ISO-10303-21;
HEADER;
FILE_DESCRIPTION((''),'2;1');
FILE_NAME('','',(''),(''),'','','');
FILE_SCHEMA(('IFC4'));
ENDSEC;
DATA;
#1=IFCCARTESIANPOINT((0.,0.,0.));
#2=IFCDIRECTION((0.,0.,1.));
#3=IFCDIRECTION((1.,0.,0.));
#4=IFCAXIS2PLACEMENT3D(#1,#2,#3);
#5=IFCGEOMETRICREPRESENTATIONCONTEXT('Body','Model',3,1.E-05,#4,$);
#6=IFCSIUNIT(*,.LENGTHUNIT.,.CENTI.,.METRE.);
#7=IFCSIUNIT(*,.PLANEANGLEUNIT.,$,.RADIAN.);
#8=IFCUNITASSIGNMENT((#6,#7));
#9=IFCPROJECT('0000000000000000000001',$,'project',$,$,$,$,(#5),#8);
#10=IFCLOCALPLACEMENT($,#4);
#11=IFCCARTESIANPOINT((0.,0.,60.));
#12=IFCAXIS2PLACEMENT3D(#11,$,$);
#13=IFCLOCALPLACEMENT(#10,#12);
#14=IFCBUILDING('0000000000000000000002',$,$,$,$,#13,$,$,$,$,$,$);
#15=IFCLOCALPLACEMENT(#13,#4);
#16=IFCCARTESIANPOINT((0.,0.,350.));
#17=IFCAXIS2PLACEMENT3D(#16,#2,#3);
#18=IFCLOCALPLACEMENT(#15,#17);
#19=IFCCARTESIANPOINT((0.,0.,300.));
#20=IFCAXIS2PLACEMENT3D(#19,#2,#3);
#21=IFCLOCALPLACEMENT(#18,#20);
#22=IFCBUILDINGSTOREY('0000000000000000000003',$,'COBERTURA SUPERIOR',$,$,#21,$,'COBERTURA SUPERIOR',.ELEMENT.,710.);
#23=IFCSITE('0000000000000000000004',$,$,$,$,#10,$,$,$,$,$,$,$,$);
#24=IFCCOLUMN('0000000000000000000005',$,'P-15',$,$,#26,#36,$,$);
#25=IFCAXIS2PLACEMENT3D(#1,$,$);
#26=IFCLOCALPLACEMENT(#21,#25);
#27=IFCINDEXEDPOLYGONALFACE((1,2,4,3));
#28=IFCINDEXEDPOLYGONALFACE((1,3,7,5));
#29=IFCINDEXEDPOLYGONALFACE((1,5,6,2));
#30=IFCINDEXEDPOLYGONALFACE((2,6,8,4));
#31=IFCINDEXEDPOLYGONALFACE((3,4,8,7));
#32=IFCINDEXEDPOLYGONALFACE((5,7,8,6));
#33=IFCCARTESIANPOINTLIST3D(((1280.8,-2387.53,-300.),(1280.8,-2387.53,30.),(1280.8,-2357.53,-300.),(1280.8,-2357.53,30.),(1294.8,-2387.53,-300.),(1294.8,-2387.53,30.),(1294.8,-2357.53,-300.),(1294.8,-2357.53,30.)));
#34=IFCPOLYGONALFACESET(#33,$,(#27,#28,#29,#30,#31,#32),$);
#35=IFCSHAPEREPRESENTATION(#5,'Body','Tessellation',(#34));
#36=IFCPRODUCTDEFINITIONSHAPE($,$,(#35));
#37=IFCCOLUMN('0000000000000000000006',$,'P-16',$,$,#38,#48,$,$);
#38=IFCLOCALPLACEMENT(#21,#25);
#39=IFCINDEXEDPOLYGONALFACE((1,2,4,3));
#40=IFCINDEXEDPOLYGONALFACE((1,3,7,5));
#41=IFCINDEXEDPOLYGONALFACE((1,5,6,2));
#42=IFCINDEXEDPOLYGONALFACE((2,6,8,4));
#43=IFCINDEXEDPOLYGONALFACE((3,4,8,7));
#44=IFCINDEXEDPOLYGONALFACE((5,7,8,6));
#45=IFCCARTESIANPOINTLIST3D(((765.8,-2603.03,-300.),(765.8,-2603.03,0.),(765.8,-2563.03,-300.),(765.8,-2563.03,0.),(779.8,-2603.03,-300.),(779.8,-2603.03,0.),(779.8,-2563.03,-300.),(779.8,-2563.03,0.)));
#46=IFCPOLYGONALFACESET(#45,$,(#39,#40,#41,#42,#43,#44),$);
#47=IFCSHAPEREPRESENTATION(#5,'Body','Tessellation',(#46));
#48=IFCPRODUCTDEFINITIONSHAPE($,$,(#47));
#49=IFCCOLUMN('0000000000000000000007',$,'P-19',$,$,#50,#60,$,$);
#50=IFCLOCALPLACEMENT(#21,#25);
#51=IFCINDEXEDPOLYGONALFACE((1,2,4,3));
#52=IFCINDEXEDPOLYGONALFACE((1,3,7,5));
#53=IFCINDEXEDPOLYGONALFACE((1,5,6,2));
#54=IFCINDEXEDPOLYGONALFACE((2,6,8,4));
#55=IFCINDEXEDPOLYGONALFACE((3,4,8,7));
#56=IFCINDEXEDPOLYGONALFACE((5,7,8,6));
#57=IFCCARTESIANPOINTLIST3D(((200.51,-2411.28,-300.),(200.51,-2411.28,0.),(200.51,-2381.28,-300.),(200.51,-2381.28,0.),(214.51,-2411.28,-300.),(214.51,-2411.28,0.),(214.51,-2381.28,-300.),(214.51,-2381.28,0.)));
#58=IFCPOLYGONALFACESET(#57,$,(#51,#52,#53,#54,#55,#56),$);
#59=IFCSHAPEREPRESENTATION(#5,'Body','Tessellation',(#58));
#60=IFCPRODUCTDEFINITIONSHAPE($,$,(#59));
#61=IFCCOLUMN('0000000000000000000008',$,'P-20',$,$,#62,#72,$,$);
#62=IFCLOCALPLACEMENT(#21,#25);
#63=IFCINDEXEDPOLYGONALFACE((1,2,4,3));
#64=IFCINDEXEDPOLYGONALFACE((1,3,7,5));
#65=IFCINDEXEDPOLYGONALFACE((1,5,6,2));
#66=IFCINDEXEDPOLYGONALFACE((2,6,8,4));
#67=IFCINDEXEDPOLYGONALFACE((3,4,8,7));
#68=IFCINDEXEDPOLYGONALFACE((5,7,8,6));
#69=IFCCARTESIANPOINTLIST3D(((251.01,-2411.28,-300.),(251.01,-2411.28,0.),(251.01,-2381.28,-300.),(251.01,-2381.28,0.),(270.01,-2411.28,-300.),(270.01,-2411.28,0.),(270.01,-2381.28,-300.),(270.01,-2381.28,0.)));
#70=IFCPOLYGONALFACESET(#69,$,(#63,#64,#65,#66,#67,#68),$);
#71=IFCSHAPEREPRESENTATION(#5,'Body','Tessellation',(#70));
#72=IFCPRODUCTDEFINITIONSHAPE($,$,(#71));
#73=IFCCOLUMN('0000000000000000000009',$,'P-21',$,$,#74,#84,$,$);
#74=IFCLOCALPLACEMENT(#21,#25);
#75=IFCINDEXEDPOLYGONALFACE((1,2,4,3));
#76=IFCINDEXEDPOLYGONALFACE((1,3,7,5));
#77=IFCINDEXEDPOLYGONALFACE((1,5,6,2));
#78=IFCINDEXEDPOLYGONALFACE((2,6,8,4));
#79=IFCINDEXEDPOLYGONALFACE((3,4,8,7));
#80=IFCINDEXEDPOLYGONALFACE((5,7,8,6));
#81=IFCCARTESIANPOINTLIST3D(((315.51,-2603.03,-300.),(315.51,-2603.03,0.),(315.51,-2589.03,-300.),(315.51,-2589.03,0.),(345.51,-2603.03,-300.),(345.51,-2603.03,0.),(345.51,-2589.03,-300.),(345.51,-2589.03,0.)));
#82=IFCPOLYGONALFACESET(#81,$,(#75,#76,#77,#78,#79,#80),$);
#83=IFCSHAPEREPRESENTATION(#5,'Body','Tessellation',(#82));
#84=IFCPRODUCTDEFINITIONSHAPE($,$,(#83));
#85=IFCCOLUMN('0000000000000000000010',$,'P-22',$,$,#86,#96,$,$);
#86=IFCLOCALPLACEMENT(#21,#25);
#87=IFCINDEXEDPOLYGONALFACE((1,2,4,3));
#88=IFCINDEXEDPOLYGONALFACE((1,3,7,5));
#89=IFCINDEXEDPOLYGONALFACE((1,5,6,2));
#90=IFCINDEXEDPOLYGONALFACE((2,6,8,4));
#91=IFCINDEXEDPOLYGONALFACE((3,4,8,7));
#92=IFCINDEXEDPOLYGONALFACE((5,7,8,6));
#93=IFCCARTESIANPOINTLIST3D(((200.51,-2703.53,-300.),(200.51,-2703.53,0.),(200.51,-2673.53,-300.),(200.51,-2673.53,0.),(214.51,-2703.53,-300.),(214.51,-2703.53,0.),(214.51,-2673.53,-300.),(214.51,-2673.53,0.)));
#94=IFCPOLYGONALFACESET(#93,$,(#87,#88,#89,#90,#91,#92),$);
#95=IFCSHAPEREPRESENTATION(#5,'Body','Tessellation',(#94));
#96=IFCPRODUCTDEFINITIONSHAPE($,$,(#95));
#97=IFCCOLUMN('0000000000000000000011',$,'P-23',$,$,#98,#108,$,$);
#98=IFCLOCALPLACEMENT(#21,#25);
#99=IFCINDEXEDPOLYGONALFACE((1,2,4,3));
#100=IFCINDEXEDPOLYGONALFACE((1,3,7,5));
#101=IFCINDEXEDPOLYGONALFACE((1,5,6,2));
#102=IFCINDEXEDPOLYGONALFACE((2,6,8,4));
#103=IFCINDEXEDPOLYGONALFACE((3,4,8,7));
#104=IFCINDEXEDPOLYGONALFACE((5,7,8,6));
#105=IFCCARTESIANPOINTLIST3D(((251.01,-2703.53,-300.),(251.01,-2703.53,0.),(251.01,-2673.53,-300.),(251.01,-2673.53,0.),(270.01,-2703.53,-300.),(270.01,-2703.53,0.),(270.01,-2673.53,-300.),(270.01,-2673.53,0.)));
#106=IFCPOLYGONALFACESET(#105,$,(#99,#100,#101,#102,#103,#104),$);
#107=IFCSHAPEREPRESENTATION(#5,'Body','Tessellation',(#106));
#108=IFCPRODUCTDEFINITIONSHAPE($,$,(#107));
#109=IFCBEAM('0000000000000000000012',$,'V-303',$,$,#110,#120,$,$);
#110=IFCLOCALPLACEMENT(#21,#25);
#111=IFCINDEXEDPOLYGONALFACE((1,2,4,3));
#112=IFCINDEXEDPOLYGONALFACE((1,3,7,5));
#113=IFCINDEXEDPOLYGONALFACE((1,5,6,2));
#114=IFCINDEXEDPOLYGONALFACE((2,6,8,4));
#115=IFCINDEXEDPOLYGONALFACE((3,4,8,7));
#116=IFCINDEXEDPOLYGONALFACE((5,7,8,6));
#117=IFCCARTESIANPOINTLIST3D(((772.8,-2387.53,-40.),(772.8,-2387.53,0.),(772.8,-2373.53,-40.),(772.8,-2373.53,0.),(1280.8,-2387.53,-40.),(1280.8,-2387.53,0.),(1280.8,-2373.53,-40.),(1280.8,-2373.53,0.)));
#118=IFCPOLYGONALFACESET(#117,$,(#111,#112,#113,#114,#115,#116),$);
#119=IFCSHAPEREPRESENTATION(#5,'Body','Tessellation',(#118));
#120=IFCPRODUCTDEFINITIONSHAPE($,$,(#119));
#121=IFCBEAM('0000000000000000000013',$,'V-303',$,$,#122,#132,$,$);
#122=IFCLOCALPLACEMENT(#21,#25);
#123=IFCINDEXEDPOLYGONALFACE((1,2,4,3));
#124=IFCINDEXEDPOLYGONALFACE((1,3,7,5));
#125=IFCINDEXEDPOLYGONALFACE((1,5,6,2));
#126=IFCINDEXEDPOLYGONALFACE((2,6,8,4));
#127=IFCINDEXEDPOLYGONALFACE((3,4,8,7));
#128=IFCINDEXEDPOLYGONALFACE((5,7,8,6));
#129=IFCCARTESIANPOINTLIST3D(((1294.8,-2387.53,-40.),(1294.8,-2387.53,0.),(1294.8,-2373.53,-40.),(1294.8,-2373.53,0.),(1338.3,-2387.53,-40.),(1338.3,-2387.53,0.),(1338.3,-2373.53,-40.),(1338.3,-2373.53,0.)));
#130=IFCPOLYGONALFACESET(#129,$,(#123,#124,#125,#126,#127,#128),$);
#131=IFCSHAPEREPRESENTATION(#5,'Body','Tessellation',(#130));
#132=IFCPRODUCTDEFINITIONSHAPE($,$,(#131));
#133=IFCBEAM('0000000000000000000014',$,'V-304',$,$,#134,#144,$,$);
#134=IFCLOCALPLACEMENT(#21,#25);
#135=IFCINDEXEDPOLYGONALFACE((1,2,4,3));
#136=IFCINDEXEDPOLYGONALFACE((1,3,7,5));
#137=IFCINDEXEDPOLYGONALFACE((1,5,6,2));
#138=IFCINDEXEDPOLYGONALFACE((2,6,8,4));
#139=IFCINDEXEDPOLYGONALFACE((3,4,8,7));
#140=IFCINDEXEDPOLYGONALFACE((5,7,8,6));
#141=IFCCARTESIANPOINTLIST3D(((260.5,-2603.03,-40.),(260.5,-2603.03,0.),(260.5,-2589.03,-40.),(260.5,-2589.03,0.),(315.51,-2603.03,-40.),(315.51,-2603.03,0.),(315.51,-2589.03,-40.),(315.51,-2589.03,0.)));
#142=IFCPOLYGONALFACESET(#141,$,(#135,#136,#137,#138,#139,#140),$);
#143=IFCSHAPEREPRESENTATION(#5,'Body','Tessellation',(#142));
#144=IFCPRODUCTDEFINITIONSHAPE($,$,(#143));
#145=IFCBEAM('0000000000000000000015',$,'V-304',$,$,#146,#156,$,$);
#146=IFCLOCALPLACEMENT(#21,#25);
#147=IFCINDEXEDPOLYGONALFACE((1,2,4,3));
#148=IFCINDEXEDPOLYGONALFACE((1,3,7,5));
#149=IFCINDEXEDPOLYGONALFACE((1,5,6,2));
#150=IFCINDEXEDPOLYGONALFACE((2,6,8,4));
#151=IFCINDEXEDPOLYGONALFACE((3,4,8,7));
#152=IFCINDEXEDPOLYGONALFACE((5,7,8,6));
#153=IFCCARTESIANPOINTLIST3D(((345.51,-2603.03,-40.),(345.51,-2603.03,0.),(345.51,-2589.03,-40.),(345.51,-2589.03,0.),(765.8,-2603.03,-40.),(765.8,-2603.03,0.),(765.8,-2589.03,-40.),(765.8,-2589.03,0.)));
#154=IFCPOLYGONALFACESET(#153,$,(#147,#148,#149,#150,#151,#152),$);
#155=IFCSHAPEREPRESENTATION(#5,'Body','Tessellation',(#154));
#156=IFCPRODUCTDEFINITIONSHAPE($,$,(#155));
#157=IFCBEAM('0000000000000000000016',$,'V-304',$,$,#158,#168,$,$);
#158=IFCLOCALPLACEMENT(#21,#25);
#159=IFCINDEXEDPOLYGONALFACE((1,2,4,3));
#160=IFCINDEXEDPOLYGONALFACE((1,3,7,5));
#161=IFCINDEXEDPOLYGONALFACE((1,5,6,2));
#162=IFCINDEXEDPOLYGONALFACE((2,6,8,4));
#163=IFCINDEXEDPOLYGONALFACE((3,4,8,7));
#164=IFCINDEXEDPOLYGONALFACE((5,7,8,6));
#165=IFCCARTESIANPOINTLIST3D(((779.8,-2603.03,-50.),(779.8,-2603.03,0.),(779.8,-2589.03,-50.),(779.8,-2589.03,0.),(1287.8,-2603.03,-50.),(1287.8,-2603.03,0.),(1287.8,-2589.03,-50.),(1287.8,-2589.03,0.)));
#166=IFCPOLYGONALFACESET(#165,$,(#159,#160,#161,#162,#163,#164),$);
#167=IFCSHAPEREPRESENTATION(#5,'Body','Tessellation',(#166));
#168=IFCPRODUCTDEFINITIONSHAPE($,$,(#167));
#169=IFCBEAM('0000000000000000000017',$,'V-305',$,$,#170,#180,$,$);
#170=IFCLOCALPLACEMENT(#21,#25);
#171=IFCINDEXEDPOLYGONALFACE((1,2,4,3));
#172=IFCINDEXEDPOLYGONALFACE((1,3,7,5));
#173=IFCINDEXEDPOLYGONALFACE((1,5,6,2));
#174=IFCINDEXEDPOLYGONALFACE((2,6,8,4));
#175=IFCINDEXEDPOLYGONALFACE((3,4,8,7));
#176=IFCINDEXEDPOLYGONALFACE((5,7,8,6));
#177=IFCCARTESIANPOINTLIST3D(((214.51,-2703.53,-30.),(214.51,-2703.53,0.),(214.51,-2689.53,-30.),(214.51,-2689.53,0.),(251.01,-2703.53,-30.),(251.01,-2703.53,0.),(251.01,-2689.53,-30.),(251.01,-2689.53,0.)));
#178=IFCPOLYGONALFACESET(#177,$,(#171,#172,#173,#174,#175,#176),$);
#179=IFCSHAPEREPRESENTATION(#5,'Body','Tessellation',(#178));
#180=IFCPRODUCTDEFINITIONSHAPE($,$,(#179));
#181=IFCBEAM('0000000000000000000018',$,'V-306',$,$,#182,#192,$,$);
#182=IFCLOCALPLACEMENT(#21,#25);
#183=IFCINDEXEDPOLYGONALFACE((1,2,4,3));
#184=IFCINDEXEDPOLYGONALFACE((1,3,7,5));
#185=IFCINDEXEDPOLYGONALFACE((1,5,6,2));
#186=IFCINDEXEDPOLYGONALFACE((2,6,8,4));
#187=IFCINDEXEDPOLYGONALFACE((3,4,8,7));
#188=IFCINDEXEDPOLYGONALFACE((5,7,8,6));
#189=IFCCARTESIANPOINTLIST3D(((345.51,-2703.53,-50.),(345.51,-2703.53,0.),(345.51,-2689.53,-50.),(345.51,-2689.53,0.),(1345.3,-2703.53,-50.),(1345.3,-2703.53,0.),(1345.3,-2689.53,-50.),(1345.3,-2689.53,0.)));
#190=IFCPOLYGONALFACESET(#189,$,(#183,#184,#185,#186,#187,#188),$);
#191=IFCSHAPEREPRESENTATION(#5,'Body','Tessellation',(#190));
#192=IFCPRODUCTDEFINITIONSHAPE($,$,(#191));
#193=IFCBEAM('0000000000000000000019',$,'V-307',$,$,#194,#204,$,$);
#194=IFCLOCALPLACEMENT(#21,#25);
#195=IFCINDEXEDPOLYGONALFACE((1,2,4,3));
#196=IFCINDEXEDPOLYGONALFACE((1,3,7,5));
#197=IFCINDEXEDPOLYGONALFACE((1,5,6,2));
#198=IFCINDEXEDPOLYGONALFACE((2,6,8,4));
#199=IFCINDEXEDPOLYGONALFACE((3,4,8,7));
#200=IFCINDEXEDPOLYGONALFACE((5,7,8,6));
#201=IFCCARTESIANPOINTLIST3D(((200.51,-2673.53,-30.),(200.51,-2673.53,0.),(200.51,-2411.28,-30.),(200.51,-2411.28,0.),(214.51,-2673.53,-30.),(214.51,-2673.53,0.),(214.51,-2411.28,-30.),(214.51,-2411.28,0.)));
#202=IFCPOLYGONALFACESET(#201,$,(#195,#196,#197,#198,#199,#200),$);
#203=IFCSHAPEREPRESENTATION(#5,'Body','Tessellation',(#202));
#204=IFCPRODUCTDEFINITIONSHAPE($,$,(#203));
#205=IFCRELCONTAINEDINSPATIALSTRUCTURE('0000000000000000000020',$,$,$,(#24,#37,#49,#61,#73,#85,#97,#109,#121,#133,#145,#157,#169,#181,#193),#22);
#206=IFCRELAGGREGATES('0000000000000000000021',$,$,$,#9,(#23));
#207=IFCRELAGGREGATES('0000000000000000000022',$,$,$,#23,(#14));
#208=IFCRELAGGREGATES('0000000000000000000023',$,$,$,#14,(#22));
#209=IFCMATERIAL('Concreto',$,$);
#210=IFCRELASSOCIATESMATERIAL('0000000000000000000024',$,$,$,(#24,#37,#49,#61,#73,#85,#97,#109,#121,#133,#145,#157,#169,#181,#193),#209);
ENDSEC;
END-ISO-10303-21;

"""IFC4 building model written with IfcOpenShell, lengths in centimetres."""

from ifc_helpers import new_model, si_unit, frame, origin_with_axes, origin_2d_with_axis, place, context, project, spatial, rectangle, extrude, material, element, save


model = new_model("IFC4")

# Units and contexts
model_context = context("Model", 3, precision=1e-05, world=origin_with_axes(), identifier="Body")
ifc_project = project(units=[si_unit("LENGTHUNIT", "METRE", prefix="CENTI"), si_unit("PLANEANGLEUNIT", "RADIAN")], contexts=[model_context])

# Site, building, storey
site_placement = place(None, origin_with_axes())
site = spatial("IfcSite", under=ifc_project, at=site_placement)
building_placement = place(site_placement, frame((0.0, 0.0, 60.0)))
building = spatial("IfcBuilding", under=site, at=building_placement)
placement_1 = place(building_placement, origin_with_axes())
placement_2 = place(placement_1, frame((0.0, 0.0, 350.0), z_axis=(0.0, 0.0, 1.0), x_axis=(1.0, 0.0, 0.0)))
storey_placement = place(placement_2, frame((0.0, 0.0, 300.0), z_axis=(0.0, 0.0, 1.0), x_axis=(1.0, 0.0, 0.0)))
storey = spatial("IfcBuildingStorey", under=building, at=storey_placement, Name="COBERTURA SUPERIOR", LongName="COBERTURA SUPERIOR", CompositionType="ELEMENT", Elevation=710.0)

# Columns
ifc_material = material(Name="Concreto")
column_1_placement = place(storey_placement, frame((1287.8, -2372.53, 30.0), z_axis=(0.0, 0.0, 1.0), x_axis=(1.0, 0.0, 0.0)))
element("IfcColumn", 1, at=column_1_placement, inside=storey, material=ifc_material, Name="P-15", context=model_context, shape_type="SolidModel", body=[
    extrude(rectangle(XDim=14.0, YDim=30.0, at=origin_2d_with_axis()), origin_with_axes(), (0.0, 0.0, -1.0), 330.0),
])
column_2_placement = place(storey_placement, frame((772.8, -2583.03, 0.0), z_axis=(0.0, 0.0, 1.0), x_axis=(1.0, 0.0, 0.0)))
element("IfcColumn", 2, at=column_2_placement, inside=storey, material=ifc_material, Name="P-16", context=model_context, shape_type="SolidModel", body=[
    extrude(rectangle(XDim=14.0, YDim=40.0, at=origin_2d_with_axis()), origin_with_axes(), (0.0, 0.0, -1.0), 300.0),
])
column_3_placement = place(storey_placement, frame((207.51, -2396.28, 0.0), z_axis=(0.0, 0.0, 1.0), x_axis=(1.0, 0.0, 0.0)))
element("IfcColumn", 3, at=column_3_placement, inside=storey, material=ifc_material, Name="P-19", context=model_context, shape_type="SolidModel", body=[
    extrude(rectangle(XDim=14.0, YDim=30.0, at=origin_2d_with_axis()), origin_with_axes(), (0.0, 0.0, -1.0), 300.0),
])
column_4_placement = place(storey_placement, frame((260.51, -2396.28, 0.0), z_axis=(0.0, 0.0, 1.0), x_axis=(1.0, 0.0, 0.0)))
element("IfcColumn", 4, at=column_4_placement, inside=storey, material=ifc_material, Name="P-20", context=model_context, shape_type="SolidModel", body=[
    extrude(rectangle(XDim=19.0, YDim=30.0, at=origin_2d_with_axis()), origin_with_axes(), (0.0, 0.0, -1.0), 300.0),
])
column_5_placement = place(storey_placement, frame((330.51, -2596.03, 0.0), z_axis=(0.0, 0.0, 1.0), x_axis=(1.0, 0.0, 0.0)))
element("IfcColumn", 5, at=column_5_placement, inside=storey, material=ifc_material, Name="P-21", context=model_context, shape_type="SolidModel", body=[
    extrude(rectangle(XDim=14.0, YDim=30.0, at=origin_2d_with_axis()), frame((0.0, 0.0, 0.0), z_axis=(0.0, 0.0, 1.0), x_axis=(0.0, -1.0, 0.0)), (0.0, 0.0, -1.0), 300.0),
])
column_6_placement = place(storey_placement, frame((207.51, -2688.53, 0.0), z_axis=(0.0, 0.0, 1.0), x_axis=(1.0, 0.0, 0.0)))
element("IfcColumn", 6, at=column_6_placement, inside=storey, material=ifc_material, Name="P-22", context=model_context, shape_type="SolidModel", body=[
    extrude(rectangle(XDim=14.0, YDim=30.0, at=origin_2d_with_axis()), origin_with_axes(), (0.0, 0.0, -1.0), 300.0),
])
column_7_placement = place(storey_placement, frame((260.51, -2688.53, 0.0), z_axis=(0.0, 0.0, 1.0), x_axis=(1.0, 0.0, 0.0)))
element("IfcColumn", 7, at=column_7_placement, inside=storey, material=ifc_material, Name="P-23", context=model_context, shape_type="SolidModel", body=[
    extrude(rectangle(XDim=19.0, YDim=30.0, at=origin_2d_with_axis()), origin_with_axes(), (0.0, 0.0, -1.0), 300.0),
])

# Beams
beam_1_placement = place(storey_placement, frame((1026.8, -2380.53, 0.0), z_axis=(0.0, 0.0, 1.0), x_axis=(1.0, 0.0, 0.0)))
element("IfcBeam", 8, at=beam_1_placement, inside=storey, material=ifc_material, Name="V-303", context=model_context, shape_type="SolidModel", body=[
    extrude(rectangle(XDim=14.0, YDim=40.0, at=origin_2d_with_axis()), frame((-254.0, 0.0, -20.0), z_axis=(1.0, 0.0, 0.0), x_axis=(0.0, -1.0, 0.0)), (0.0, 0.0, 1.0), 508.0),
])
beam_2_placement = place(storey_placement, frame((1316.55, -2380.53, 0.0), z_axis=(0.0, 0.0, 1.0), x_axis=(1.0, 0.0, 0.0)))
element("IfcBeam", 9, at=beam_2_placement, inside=storey, material=ifc_material, Name="V-303", context=model_context, shape_type="SolidModel", body=[
    extrude(rectangle(XDim=14.0, YDim=40.0, at=origin_2d_with_axis()), frame((-21.75, 0.0, -20.0), z_axis=(1.0, 0.0, 0.0), x_axis=(0.0, -1.0, 0.0)), (0.0, 0.0, 1.0), 43.5),
])
beam_3_placement = place(storey_placement, frame((288.0, -2596.03, 0.0), z_axis=(0.0, 0.0, 1.0), x_axis=(1.0, 0.0, 0.0)))
element("IfcBeam", 10, at=beam_3_placement, inside=storey, material=ifc_material, Name="V-304", context=model_context, shape_type="SolidModel", body=[
    extrude(rectangle(XDim=14.0, YDim=40.0, at=origin_2d_with_axis()), frame((-27.5, 0.0, -20.0), z_axis=(1.0, 0.0, 0.0), x_axis=(0.0, -1.0, 0.0)), (0.0, 0.0, 1.0), 55.01),
])
beam_4_placement = place(storey_placement, frame((555.65, -2596.03, 0.0), z_axis=(0.0, 0.0, 1.0), x_axis=(1.0, 0.0, 0.0)))
element("IfcBeam", 11, at=beam_4_placement, inside=storey, material=ifc_material, Name="V-304", context=model_context, shape_type="SolidModel", body=[
    extrude(rectangle(XDim=14.0, YDim=40.0, at=origin_2d_with_axis()), frame((-210.15, 0.0, -20.0), z_axis=(1.0, 0.0, 0.0), x_axis=(0.0, -1.0, 0.0)), (0.0, 0.0, 1.0), 420.29),
])
beam_5_placement = place(storey_placement, frame((1033.8, -2596.03, 0.0), z_axis=(0.0, 0.0, 1.0), x_axis=(1.0, 0.0, 0.0)))
element("IfcBeam", 12, at=beam_5_placement, inside=storey, material=ifc_material, Name="V-304", context=model_context, shape_type="SolidModel", body=[
    extrude(rectangle(XDim=14.0, YDim=50.0, at=origin_2d_with_axis()), frame((-254.0, 0.0, -25.0), z_axis=(1.0, 0.0, 0.0), x_axis=(0.0, -1.0, 0.0)), (0.0, 0.0, 1.0), 508.0),
])
beam_6_placement = place(storey_placement, frame((232.76, -2696.53, 0.0), z_axis=(0.0, 0.0, 1.0), x_axis=(1.0, 0.0, 0.0)))
element("IfcBeam", 13, at=beam_6_placement, inside=storey, material=ifc_material, Name="V-305", context=model_context, shape_type="SolidModel", body=[
    extrude(rectangle(XDim=14.0, YDim=30.0, at=origin_2d_with_axis()), frame((-18.25, 0.0, -15.0), z_axis=(1.0, 0.0, 0.0), x_axis=(0.0, -1.0, 0.0)), (0.0, 0.0, 1.0), 36.5),
])
beam_7_placement = place(storey_placement, frame((845.4, -2696.53, 0.0), z_axis=(0.0, 0.0, 1.0), x_axis=(1.0, 0.0, 0.0)))
element("IfcBeam", 14, at=beam_7_placement, inside=storey, material=ifc_material, Name="V-306", context=model_context, shape_type="SolidModel", body=[
    extrude(rectangle(XDim=14.0, YDim=50.0, at=origin_2d_with_axis()), frame((-499.89, 0.0, -25.0), z_axis=(1.0, 0.0, 0.0), x_axis=(0.0, -1.0, 0.0)), (0.0, 0.0, 1.0), 999.79),
])
beam_8_placement = place(storey_placement, frame((207.51, -2542.41, 0.0), z_axis=(0.0, 0.0, 1.0), x_axis=(1.0, 0.0, 0.0)))
element("IfcBeam", 15, at=beam_8_placement, inside=storey, material=ifc_material, Name="V-307", context=model_context, shape_type="SolidModel", body=[
    extrude(rectangle(XDim=14.0, YDim=30.0, at=origin_2d_with_axis()), frame((0.0, -131.12, -15.0), z_axis=(0.0, 1.0, 0.0), x_axis=(1.0, 0.0, 0.0)), (0.0, 0.0, 1.0), 262.25),
])

save(model, "model.ifc")
